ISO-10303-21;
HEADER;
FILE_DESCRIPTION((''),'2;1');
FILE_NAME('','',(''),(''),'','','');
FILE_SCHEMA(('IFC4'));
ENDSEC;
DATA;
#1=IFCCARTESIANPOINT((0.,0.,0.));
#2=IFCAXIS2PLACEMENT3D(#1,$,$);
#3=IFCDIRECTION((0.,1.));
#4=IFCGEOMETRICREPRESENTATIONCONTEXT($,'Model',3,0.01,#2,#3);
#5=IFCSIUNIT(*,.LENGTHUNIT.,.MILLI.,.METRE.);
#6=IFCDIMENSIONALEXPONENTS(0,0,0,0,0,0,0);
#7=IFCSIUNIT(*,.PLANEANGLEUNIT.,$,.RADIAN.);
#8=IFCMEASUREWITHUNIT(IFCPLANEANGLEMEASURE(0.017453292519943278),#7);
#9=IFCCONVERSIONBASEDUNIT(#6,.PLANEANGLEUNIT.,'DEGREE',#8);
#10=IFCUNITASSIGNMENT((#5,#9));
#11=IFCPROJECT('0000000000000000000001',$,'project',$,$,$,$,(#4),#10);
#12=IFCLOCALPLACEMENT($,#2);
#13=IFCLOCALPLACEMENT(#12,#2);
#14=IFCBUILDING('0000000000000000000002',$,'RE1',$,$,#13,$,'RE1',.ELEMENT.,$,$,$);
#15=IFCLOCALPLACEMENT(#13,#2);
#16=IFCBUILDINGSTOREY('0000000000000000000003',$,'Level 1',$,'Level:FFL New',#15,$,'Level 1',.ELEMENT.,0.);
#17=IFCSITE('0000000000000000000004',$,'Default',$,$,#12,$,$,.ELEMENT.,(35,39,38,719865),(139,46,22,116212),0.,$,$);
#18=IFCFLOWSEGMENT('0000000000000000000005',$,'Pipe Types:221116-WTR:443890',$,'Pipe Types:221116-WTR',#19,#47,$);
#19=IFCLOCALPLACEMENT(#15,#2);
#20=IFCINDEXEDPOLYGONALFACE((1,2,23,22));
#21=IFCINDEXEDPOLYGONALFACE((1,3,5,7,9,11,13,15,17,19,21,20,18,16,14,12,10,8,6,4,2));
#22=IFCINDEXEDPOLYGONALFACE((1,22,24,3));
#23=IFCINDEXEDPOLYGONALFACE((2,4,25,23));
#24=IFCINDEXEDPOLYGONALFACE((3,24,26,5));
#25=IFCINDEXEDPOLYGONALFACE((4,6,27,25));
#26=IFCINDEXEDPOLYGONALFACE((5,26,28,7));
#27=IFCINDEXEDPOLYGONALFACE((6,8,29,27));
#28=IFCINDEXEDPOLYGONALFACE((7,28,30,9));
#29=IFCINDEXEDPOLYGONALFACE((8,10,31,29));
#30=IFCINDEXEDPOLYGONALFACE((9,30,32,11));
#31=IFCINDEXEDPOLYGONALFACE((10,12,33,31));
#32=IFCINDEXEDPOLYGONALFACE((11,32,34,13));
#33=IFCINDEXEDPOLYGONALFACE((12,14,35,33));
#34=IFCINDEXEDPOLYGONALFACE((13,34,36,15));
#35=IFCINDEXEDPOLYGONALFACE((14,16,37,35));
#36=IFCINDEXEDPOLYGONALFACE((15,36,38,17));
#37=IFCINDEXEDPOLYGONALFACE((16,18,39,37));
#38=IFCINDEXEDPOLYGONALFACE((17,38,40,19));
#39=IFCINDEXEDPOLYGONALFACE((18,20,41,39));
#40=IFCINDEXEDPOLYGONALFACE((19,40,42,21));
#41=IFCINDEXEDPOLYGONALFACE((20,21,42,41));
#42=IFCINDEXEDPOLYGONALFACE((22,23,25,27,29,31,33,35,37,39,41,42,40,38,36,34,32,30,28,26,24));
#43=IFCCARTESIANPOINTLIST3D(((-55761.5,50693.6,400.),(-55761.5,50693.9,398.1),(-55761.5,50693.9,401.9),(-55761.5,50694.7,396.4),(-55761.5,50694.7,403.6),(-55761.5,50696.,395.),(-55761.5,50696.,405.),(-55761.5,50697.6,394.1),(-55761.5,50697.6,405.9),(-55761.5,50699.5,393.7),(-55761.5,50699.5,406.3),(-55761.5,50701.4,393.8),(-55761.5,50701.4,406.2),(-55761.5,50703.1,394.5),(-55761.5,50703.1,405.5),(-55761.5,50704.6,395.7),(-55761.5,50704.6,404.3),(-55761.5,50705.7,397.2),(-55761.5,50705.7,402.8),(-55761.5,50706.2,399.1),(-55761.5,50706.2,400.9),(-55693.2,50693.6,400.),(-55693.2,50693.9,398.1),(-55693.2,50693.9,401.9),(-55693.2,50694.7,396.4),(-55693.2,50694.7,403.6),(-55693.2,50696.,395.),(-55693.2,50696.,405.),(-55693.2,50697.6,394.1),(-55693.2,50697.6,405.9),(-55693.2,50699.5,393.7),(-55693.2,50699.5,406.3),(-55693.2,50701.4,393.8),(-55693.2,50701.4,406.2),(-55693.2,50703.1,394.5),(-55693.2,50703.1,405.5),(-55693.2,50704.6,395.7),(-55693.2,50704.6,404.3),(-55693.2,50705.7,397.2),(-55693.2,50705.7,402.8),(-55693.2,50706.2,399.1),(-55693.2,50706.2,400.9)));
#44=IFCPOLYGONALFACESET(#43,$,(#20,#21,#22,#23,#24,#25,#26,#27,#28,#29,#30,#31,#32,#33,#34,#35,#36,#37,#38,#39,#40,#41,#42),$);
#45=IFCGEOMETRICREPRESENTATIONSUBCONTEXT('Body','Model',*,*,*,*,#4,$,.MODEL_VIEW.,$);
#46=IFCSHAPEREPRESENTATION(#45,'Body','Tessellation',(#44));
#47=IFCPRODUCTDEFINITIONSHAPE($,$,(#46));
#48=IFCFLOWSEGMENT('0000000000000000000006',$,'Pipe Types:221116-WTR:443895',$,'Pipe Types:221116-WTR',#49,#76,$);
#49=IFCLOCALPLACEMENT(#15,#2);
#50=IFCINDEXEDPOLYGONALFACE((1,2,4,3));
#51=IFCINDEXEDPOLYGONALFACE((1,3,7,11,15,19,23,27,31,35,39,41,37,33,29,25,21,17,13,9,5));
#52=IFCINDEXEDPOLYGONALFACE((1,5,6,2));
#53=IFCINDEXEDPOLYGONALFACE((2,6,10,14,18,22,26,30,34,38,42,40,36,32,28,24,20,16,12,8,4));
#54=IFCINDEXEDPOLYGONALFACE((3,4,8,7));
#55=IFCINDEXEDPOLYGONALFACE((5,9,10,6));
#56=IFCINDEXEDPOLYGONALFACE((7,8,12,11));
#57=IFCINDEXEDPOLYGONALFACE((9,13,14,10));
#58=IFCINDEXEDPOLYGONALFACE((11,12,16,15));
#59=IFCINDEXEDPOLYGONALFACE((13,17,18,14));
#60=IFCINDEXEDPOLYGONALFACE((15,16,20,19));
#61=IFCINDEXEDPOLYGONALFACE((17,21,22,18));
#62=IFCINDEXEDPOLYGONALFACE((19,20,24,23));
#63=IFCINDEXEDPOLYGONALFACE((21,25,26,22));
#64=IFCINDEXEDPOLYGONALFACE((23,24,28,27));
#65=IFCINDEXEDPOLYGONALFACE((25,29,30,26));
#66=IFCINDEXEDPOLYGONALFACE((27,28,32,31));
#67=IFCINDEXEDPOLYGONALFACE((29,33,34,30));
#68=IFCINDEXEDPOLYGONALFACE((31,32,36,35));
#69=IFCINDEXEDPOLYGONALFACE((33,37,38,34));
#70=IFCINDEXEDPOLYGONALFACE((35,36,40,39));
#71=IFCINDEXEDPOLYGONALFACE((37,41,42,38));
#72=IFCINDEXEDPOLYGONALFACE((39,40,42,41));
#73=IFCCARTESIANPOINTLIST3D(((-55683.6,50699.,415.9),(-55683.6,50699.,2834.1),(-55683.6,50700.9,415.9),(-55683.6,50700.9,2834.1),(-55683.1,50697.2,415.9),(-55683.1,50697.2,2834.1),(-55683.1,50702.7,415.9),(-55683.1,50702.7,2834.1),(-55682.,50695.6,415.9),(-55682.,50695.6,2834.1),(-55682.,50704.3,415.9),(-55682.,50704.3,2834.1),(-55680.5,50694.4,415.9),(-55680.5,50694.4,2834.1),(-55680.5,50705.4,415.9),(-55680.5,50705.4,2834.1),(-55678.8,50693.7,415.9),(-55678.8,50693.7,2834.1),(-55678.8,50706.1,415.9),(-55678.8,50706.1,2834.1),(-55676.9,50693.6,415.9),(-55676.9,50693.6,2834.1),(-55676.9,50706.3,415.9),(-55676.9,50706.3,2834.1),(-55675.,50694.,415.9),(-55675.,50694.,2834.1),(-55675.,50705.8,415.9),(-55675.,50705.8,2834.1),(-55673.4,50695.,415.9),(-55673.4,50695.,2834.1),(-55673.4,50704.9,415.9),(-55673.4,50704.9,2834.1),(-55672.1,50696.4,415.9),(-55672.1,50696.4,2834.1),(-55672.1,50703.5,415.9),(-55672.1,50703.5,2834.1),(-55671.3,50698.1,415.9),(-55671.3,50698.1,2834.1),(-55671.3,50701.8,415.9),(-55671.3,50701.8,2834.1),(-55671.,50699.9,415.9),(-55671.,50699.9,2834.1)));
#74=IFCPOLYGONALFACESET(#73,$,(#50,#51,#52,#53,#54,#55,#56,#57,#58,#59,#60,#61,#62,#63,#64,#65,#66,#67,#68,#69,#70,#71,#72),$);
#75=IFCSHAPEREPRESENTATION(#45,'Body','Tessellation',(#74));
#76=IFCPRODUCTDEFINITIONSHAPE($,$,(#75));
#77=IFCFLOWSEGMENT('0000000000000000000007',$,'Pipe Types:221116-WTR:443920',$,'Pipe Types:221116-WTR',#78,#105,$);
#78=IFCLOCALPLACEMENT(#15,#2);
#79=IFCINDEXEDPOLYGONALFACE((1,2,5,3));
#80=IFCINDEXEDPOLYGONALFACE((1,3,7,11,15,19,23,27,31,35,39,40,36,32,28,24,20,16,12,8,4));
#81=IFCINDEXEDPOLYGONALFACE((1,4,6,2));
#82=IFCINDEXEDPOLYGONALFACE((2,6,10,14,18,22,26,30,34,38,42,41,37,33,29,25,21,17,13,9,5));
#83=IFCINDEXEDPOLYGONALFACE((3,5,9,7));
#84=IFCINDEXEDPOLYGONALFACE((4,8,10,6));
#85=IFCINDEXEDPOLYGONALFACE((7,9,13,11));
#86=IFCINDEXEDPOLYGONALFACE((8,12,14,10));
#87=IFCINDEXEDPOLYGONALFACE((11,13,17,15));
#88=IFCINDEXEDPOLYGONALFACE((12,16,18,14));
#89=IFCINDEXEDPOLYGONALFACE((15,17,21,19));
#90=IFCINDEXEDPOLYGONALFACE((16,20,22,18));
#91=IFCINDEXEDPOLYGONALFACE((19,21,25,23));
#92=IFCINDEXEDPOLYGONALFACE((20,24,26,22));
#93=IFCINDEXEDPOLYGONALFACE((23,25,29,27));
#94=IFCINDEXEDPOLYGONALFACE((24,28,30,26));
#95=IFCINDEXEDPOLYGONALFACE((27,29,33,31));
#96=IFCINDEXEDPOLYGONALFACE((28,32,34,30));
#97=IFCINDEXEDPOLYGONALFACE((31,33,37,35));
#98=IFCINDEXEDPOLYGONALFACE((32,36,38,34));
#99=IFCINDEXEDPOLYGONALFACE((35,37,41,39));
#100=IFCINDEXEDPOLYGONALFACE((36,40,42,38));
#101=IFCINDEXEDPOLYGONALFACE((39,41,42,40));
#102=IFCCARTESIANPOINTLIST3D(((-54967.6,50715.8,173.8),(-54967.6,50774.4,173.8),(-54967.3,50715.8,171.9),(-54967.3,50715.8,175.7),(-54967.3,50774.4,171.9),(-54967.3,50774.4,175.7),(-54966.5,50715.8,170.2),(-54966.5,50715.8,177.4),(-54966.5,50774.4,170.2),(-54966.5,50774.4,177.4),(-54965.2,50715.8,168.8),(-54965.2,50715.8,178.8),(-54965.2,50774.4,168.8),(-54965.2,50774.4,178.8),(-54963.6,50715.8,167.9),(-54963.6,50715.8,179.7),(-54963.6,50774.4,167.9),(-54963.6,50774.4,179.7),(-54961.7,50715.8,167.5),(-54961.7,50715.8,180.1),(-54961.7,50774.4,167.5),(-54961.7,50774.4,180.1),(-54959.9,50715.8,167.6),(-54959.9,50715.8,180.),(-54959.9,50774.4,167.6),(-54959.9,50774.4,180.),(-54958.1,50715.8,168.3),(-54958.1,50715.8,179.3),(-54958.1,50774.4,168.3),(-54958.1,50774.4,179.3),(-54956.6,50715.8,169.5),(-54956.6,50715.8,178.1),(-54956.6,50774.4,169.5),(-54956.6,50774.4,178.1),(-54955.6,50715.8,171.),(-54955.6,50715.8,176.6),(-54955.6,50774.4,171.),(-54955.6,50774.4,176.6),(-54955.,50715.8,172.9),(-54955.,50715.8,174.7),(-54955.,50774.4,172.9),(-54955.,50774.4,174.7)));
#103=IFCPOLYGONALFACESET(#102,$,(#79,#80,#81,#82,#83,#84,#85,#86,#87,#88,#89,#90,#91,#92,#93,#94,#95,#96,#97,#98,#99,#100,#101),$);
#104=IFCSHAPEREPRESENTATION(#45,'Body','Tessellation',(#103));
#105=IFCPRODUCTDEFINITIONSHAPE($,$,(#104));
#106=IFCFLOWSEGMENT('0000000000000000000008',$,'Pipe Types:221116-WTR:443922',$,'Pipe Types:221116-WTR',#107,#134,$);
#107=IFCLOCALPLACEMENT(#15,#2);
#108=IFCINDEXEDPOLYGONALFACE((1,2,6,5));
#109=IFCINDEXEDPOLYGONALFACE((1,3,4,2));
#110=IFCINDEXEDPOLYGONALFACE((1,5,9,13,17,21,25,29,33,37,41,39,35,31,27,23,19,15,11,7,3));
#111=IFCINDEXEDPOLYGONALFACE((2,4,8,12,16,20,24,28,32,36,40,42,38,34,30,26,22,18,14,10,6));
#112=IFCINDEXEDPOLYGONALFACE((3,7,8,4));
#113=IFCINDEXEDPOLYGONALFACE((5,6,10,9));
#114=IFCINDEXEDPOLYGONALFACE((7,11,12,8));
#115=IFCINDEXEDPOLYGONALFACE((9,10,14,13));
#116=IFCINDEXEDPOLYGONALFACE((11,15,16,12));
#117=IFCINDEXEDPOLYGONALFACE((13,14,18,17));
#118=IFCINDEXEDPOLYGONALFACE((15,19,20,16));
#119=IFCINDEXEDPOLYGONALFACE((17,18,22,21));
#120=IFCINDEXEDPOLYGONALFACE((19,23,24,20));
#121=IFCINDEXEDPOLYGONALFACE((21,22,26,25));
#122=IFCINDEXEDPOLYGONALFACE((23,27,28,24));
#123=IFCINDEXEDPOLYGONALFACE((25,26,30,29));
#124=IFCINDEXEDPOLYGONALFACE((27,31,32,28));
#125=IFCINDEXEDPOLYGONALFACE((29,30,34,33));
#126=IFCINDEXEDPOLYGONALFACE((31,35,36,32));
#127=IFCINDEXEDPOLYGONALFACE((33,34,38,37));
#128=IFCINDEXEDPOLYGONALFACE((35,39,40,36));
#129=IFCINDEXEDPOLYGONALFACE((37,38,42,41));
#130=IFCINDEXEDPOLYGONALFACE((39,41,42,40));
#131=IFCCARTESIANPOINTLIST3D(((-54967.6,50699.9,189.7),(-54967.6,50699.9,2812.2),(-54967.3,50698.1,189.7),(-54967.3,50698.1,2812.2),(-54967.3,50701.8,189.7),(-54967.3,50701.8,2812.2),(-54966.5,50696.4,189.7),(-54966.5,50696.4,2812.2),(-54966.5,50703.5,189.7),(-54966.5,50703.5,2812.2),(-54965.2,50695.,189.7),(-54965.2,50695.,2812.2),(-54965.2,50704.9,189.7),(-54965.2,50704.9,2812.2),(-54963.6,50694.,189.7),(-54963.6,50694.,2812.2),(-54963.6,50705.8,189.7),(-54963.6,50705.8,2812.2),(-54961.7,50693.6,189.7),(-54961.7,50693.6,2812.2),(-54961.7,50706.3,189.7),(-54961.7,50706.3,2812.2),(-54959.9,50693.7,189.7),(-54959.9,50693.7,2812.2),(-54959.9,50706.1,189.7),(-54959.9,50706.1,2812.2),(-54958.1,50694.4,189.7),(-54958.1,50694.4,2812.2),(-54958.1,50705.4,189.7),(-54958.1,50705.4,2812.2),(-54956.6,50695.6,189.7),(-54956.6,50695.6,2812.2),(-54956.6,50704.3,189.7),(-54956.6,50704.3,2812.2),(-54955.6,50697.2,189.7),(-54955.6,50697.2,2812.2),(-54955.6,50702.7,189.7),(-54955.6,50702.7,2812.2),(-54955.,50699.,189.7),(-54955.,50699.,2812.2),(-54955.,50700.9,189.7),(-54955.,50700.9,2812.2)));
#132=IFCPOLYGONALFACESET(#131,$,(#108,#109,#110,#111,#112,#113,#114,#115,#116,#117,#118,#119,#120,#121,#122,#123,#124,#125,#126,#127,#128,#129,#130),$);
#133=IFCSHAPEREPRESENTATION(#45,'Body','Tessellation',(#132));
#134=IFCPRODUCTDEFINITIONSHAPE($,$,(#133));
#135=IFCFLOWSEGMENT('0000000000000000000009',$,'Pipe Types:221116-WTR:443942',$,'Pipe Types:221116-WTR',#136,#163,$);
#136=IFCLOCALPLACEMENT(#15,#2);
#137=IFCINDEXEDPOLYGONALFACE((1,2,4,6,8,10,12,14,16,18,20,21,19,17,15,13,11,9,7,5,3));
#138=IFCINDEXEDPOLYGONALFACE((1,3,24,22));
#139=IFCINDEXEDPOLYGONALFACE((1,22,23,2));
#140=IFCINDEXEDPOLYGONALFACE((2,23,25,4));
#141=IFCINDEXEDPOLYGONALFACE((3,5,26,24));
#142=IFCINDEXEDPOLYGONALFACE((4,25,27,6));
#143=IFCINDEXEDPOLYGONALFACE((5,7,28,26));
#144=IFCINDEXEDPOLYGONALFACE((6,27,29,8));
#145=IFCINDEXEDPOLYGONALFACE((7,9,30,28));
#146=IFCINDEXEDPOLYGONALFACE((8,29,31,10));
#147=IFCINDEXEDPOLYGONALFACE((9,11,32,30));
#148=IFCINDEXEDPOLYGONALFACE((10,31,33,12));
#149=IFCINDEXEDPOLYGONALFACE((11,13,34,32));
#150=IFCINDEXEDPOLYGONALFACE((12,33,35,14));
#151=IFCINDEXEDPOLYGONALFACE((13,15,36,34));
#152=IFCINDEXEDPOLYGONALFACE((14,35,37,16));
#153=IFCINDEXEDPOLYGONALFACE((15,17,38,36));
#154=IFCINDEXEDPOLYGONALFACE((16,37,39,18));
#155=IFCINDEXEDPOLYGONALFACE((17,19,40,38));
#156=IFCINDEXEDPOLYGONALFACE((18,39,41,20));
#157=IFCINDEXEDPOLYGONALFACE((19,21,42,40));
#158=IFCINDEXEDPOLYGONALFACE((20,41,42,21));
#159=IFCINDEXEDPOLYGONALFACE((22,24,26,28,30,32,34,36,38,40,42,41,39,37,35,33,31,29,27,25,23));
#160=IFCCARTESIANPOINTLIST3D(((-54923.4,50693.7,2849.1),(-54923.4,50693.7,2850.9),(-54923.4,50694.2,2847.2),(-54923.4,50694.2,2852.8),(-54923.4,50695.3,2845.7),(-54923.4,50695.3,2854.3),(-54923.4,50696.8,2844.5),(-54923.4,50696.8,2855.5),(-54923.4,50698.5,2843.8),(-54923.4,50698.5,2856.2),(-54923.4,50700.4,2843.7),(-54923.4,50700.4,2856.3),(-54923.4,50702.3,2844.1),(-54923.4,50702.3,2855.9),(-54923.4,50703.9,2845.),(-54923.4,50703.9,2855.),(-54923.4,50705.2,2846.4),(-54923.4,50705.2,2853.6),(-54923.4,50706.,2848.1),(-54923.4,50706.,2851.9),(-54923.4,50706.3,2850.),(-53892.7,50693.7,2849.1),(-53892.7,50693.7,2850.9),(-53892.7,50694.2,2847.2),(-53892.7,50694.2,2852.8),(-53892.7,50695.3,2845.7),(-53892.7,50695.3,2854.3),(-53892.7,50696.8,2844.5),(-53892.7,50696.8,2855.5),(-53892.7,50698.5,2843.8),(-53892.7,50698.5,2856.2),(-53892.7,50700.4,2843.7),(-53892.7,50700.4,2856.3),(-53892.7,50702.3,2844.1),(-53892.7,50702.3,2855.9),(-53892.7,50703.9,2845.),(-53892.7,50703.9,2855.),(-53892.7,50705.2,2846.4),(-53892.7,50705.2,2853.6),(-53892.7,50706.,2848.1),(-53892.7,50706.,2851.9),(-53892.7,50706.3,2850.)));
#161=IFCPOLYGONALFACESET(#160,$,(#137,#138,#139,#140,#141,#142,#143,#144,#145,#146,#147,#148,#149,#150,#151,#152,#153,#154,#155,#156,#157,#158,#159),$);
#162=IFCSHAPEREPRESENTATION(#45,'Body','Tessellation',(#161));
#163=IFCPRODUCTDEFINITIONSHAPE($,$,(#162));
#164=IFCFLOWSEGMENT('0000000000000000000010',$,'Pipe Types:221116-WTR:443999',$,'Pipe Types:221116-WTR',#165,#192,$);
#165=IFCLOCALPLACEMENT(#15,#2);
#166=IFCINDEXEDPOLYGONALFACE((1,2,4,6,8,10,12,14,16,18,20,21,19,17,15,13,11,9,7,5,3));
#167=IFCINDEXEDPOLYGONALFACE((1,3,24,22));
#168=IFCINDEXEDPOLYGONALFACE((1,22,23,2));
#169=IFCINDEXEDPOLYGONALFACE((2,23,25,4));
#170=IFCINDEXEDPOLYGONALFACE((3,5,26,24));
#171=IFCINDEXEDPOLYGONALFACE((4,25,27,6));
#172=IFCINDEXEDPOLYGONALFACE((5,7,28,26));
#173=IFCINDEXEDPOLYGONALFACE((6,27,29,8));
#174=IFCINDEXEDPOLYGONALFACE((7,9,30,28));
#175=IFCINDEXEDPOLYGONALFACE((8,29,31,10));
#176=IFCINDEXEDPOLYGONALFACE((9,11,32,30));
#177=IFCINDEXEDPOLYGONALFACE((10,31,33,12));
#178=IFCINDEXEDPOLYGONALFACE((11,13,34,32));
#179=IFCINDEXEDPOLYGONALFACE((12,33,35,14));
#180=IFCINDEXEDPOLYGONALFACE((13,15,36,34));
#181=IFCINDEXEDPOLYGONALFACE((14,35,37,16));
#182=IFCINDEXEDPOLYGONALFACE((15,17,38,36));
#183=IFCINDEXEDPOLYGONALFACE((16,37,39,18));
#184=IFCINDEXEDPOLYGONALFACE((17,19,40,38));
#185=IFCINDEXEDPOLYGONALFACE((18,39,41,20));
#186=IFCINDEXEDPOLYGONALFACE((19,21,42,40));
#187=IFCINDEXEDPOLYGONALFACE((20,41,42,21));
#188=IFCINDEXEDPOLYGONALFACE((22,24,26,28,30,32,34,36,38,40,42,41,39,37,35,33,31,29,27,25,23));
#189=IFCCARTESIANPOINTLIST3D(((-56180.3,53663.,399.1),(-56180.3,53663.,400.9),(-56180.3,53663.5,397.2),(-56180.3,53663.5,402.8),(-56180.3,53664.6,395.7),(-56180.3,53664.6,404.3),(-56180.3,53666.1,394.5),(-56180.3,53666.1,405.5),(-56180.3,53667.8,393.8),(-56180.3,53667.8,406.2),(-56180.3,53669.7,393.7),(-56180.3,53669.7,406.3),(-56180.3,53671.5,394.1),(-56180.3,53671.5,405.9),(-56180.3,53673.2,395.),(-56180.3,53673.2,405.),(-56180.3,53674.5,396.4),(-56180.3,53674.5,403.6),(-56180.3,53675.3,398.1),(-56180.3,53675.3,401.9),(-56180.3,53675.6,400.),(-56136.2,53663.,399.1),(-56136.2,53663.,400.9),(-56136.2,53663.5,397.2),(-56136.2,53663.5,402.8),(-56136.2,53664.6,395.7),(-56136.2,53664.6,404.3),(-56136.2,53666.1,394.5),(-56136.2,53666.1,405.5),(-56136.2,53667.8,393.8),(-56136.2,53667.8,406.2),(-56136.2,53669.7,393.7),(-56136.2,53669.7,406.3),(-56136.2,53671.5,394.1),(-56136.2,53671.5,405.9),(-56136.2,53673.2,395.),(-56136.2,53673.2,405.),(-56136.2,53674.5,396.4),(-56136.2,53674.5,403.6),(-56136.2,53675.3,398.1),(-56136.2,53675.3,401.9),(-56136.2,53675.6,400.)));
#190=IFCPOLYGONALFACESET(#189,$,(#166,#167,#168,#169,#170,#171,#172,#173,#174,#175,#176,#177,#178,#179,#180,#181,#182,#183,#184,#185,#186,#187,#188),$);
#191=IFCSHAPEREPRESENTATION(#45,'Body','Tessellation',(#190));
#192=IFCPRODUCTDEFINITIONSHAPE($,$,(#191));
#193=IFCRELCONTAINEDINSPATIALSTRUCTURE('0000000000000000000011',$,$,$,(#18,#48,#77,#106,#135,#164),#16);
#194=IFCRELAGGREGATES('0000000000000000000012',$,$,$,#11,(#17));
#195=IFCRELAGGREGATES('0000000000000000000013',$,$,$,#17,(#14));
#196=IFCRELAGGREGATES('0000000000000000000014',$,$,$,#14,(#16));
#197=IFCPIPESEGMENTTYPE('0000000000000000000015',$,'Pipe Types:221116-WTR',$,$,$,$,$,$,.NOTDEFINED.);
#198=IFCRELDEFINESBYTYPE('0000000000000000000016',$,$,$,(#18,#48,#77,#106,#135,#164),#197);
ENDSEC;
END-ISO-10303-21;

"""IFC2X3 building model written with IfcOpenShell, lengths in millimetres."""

from ifc_helpers import new_model, entity, si_unit, converted_unit, direction, frame, frame_2d, origin, origin_2d_with_axis, place, context, subcontext, project, spatial, circle, extrude, type_object, element, save


model = new_model("IFC2X3")

# Units and contexts
model_context = context("Model", 3, precision=0.01, world=origin(), true_north=direction((0.0, 1.0)))
body_context = subcontext(model_context, "Body", "Model", "MODEL_VIEW")
ifc_project = project(units=[si_unit("LENGTHUNIT", "METRE", prefix="MILLI"), converted_unit("PLANEANGLEUNIT", "DEGREE", entity("IfcPlaneAngleMeasure", 0.017453292519943278), si_unit("PLANEANGLEUNIT", "RADIAN"), dimensions=[0, 0, 0, 0, 0, 0, 0])], contexts=[model_context])

# Site, building, storey
site_placement = place(None, origin())
site = spatial("IfcSite", under=ifc_project, at=site_placement, Name="Default", CompositionType="ELEMENT", RefLatitude=(35, 39, 38, 719865), RefLongitude=(139, 46, 22, 116212), RefElevation=0.0)
building_placement = place(site_placement, origin())
building = spatial("IfcBuilding", under=site, at=building_placement, Name="RE1", LongName="RE1", CompositionType="ELEMENT")
storey_placement = place(building_placement, origin())
storey = spatial("IfcBuildingStorey", under=building, at=storey_placement, Name="Level 1", ObjectType="Level:FFL New", LongName="Level 1", CompositionType="ELEMENT", Elevation=0.0)

# Flow segments
pipe_segment_type_1 = type_object("IfcPipeSegmentType", Name="Pipe Types:221116-WTR", PredefinedType="NOTDEFINED")
flow_segment_1_placement = place(storey_placement, origin())
element("IfcFlowSegment", 1, at=flow_segment_1_placement, inside=storey, type_object=pipe_segment_type_1, Name="Pipe Types:221116-WTR:443890", ObjectType="Pipe Types:221116-WTR", context=body_context, shape_type="SweptSolid", body=[
    extrude(circle(Radius=6.3, at=origin_2d_with_axis()), frame((-55761.5, 50699.9, 400.0), z_axis=(1.0, 0.0, 0.0), x_axis=(0.0, -1.0, 0.0)), (0.0, 0.0, 1.0), 68.2),
])
flow_segment_2_placement = place(storey_placement, origin())
element("IfcFlowSegment", 2, at=flow_segment_2_placement, inside=storey, type_object=pipe_segment_type_1, Name="Pipe Types:221116-WTR:443895", ObjectType="Pipe Types:221116-WTR", context=body_context, shape_type="SweptSolid", body=[
    extrude(circle(Radius=6.3, at=origin_2d_with_axis()), frame((-55677.4, 50699.9, 415.9)), (0.0, 0.0, 1.0), 2418.2),
])
flow_segment_3_placement = place(storey_placement, origin())
element("IfcFlowSegment", 3, at=flow_segment_3_placement, inside=storey, type_object=pipe_segment_type_1, Name="Pipe Types:221116-WTR:443920", ObjectType="Pipe Types:221116-WTR", context=body_context, shape_type="SweptSolid", body=[
    extrude(circle(Radius=6.3, at=origin_2d_with_axis()), frame((-54961.3, 50715.8, 173.8), z_axis=(0.0, 1.0, 0.0), x_axis=(-1.0, 0.0, 0.0)), (0.0, 0.0, 1.0), 58.6),
])
flow_segment_4_placement = place(storey_placement, origin())
element("IfcFlowSegment", 4, at=flow_segment_4_placement, inside=storey, type_object=pipe_segment_type_1, Name="Pipe Types:221116-WTR:443922", ObjectType="Pipe Types:221116-WTR", context=body_context, shape_type="SweptSolid", body=[
    extrude(circle(Radius=6.3, at=frame_2d((0.0, 0.0), x_axis=(1.0, 0.0))), frame((-54961.3, 50699.9, 189.7), z_axis=(0.0, 0.0, 1.0), x_axis=(-1.0, 0.0, 0.0)), (0.0, 0.0, 1.0), 2622.5),
])
flow_segment_5_placement = place(storey_placement, origin())
element("IfcFlowSegment", 5, at=flow_segment_5_placement, inside=storey, type_object=pipe_segment_type_1, Name="Pipe Types:221116-WTR:443942", ObjectType="Pipe Types:221116-WTR", context=body_context, shape_type="SweptSolid", body=[
    extrude(circle(Radius=6.3, at=origin_2d_with_axis()), frame((-54923.4, 50699.9, 2850.0), z_axis=(1.0, 0.0, 0.0), x_axis=(0.0, 1.0, 0.0)), (0.0, 0.0, 1.0), 1030.8),
])
flow_segment_6_placement = place(storey_placement, origin())
element("IfcFlowSegment", 6, at=flow_segment_6_placement, inside=storey, type_object=pipe_segment_type_1, Name="Pipe Types:221116-WTR:443999", ObjectType="Pipe Types:221116-WTR", context=body_context, shape_type="SweptSolid", body=[
    extrude(circle(Radius=6.3, at=frame_2d((0.0, 0.0), x_axis=(1.0, 0.0))), frame((-56180.3, 53669.2, 400.0), z_axis=(1.0, 0.0, 0.0), x_axis=(0.0, 1.0, 0.0)), (0.0, 0.0, 1.0), 44.1),
])

save(model, "model.ifc")
